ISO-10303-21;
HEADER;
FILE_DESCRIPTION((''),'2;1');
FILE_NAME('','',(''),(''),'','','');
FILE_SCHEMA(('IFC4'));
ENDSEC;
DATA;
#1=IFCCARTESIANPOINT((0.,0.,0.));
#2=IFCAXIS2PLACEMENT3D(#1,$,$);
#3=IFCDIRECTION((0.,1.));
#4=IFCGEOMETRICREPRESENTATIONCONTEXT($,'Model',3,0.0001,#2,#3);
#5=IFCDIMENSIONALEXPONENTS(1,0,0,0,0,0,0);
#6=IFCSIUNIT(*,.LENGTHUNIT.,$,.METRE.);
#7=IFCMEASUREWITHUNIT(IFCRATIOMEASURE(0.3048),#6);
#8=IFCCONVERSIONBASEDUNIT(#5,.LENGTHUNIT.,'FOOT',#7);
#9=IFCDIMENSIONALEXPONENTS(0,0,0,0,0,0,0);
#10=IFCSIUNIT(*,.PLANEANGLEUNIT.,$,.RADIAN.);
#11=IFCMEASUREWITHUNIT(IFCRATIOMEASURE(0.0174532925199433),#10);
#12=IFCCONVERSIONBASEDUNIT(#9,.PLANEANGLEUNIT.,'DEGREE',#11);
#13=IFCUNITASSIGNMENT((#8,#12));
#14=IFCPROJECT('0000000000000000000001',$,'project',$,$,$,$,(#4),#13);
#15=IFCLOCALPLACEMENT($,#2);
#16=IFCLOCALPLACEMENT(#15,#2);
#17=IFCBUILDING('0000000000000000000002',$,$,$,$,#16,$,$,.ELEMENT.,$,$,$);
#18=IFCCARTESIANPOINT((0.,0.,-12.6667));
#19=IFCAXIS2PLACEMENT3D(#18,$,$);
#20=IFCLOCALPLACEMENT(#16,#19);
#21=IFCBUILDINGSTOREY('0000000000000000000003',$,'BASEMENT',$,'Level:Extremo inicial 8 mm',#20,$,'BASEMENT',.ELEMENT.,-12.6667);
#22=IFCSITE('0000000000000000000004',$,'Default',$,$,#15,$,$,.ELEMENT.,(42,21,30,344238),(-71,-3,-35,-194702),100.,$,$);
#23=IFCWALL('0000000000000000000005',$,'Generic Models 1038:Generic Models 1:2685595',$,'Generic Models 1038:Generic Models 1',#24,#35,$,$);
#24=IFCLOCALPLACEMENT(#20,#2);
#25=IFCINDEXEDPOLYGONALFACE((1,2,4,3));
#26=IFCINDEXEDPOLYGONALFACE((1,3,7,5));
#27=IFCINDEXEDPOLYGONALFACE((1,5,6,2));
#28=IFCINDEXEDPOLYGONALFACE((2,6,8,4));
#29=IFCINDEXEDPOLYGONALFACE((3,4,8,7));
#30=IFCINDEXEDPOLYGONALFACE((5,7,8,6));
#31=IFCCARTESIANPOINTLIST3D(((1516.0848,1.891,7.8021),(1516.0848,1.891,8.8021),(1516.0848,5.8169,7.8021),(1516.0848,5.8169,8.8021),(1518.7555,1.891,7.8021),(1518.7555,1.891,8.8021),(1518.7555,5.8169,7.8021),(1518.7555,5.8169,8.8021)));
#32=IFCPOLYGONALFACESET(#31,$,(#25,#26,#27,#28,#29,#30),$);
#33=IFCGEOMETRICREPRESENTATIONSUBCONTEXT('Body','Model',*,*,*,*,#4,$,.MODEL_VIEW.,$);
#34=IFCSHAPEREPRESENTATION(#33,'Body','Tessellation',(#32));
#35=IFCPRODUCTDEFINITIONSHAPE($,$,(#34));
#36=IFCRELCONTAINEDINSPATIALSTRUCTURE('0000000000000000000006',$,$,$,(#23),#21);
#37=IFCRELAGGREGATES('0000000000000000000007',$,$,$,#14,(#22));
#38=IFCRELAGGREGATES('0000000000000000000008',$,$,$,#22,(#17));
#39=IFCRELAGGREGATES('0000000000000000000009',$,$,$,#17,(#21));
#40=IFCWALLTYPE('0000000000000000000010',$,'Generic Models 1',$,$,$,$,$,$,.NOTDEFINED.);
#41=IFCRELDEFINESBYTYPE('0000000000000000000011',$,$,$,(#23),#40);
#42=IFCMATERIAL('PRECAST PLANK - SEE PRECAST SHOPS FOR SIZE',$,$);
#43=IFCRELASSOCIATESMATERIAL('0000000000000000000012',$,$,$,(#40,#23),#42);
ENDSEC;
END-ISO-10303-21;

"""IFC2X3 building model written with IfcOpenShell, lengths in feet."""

from ifc_helpers import new_model, entity, si_unit, converted_unit, direction, frame, frame_2d, origin, place, context, subcontext, project, spatial, rectangle, extrude, material, type_object, element, save


model = new_model("IFC2X3")

# Units and contexts
model_context = context("Model", 3, precision=0.0001, world=origin(), true_north=direction((0.0, 1.0)))
body_context = subcontext(model_context, "Body", "Model", "MODEL_VIEW")
ifc_project = project(units=[converted_unit("LENGTHUNIT", "FOOT", entity("IfcRatioMeasure", 0.3048), si_unit("LENGTHUNIT", "METRE"), dimensions=[1, 0, 0, 0, 0, 0, 0]), converted_unit("PLANEANGLEUNIT", "DEGREE", entity("IfcRatioMeasure", 0.0174532925199433), si_unit("PLANEANGLEUNIT", "RADIAN"), dimensions=[0, 0, 0, 0, 0, 0, 0])], contexts=[model_context])

# Site, building, storey
site_placement = place(None, origin())
site = spatial("IfcSite", under=ifc_project, at=site_placement, Name="Default", CompositionType="ELEMENT", RefLatitude=(42, 21, 30, 344238), RefLongitude=(-71, -3, -35, -194702), RefElevation=100.0)
building_placement = place(site_placement, origin())
building = spatial("IfcBuilding", under=site, at=building_placement, CompositionType="ELEMENT")
storey_placement = place(building_placement, frame((0.0, 0.0, -12.6667)))
storey = spatial("IfcBuildingStorey", under=building, at=storey_placement, Name="BASEMENT", ObjectType="Level:Extremo inicial 8 mm", LongName="BASEMENT", CompositionType="ELEMENT", Elevation=-12.6667)

# Wall
ifc_material_1 = material(Name="PRECAST PLANK - SEE PRECAST SHOPS FOR SIZE")
wall_type_1 = type_object("IfcWallType", Name="Generic Models 1", PredefinedType="NOTDEFINED", material=ifc_material_1)
wall_1_placement = place(storey_placement, frame((1516.0848, 1.891, 7.8021), z_axis=(0.0, 0.0, 1.0), x_axis=(0.0, 1.0, 0.0)))
element("IfcWall", 1, at=wall_1_placement, inside=storey, type_object=wall_type_1, material=ifc_material_1, Name="Generic Models 1038:Generic Models 1:2685595", ObjectType="Generic Models 1038:Generic Models 1", context=body_context, shape_type="SweptSolid", body=[
    extrude(rectangle(XDim=3.9258, YDim=2.6707, at=frame_2d((0.0, 0.0), x_axis=(1.0, 0.0))), frame((1.9629, -1.3353, 0.0)), (0.0, 0.0, 1.0), 1.0),
])

save(model, "model.ifc")
